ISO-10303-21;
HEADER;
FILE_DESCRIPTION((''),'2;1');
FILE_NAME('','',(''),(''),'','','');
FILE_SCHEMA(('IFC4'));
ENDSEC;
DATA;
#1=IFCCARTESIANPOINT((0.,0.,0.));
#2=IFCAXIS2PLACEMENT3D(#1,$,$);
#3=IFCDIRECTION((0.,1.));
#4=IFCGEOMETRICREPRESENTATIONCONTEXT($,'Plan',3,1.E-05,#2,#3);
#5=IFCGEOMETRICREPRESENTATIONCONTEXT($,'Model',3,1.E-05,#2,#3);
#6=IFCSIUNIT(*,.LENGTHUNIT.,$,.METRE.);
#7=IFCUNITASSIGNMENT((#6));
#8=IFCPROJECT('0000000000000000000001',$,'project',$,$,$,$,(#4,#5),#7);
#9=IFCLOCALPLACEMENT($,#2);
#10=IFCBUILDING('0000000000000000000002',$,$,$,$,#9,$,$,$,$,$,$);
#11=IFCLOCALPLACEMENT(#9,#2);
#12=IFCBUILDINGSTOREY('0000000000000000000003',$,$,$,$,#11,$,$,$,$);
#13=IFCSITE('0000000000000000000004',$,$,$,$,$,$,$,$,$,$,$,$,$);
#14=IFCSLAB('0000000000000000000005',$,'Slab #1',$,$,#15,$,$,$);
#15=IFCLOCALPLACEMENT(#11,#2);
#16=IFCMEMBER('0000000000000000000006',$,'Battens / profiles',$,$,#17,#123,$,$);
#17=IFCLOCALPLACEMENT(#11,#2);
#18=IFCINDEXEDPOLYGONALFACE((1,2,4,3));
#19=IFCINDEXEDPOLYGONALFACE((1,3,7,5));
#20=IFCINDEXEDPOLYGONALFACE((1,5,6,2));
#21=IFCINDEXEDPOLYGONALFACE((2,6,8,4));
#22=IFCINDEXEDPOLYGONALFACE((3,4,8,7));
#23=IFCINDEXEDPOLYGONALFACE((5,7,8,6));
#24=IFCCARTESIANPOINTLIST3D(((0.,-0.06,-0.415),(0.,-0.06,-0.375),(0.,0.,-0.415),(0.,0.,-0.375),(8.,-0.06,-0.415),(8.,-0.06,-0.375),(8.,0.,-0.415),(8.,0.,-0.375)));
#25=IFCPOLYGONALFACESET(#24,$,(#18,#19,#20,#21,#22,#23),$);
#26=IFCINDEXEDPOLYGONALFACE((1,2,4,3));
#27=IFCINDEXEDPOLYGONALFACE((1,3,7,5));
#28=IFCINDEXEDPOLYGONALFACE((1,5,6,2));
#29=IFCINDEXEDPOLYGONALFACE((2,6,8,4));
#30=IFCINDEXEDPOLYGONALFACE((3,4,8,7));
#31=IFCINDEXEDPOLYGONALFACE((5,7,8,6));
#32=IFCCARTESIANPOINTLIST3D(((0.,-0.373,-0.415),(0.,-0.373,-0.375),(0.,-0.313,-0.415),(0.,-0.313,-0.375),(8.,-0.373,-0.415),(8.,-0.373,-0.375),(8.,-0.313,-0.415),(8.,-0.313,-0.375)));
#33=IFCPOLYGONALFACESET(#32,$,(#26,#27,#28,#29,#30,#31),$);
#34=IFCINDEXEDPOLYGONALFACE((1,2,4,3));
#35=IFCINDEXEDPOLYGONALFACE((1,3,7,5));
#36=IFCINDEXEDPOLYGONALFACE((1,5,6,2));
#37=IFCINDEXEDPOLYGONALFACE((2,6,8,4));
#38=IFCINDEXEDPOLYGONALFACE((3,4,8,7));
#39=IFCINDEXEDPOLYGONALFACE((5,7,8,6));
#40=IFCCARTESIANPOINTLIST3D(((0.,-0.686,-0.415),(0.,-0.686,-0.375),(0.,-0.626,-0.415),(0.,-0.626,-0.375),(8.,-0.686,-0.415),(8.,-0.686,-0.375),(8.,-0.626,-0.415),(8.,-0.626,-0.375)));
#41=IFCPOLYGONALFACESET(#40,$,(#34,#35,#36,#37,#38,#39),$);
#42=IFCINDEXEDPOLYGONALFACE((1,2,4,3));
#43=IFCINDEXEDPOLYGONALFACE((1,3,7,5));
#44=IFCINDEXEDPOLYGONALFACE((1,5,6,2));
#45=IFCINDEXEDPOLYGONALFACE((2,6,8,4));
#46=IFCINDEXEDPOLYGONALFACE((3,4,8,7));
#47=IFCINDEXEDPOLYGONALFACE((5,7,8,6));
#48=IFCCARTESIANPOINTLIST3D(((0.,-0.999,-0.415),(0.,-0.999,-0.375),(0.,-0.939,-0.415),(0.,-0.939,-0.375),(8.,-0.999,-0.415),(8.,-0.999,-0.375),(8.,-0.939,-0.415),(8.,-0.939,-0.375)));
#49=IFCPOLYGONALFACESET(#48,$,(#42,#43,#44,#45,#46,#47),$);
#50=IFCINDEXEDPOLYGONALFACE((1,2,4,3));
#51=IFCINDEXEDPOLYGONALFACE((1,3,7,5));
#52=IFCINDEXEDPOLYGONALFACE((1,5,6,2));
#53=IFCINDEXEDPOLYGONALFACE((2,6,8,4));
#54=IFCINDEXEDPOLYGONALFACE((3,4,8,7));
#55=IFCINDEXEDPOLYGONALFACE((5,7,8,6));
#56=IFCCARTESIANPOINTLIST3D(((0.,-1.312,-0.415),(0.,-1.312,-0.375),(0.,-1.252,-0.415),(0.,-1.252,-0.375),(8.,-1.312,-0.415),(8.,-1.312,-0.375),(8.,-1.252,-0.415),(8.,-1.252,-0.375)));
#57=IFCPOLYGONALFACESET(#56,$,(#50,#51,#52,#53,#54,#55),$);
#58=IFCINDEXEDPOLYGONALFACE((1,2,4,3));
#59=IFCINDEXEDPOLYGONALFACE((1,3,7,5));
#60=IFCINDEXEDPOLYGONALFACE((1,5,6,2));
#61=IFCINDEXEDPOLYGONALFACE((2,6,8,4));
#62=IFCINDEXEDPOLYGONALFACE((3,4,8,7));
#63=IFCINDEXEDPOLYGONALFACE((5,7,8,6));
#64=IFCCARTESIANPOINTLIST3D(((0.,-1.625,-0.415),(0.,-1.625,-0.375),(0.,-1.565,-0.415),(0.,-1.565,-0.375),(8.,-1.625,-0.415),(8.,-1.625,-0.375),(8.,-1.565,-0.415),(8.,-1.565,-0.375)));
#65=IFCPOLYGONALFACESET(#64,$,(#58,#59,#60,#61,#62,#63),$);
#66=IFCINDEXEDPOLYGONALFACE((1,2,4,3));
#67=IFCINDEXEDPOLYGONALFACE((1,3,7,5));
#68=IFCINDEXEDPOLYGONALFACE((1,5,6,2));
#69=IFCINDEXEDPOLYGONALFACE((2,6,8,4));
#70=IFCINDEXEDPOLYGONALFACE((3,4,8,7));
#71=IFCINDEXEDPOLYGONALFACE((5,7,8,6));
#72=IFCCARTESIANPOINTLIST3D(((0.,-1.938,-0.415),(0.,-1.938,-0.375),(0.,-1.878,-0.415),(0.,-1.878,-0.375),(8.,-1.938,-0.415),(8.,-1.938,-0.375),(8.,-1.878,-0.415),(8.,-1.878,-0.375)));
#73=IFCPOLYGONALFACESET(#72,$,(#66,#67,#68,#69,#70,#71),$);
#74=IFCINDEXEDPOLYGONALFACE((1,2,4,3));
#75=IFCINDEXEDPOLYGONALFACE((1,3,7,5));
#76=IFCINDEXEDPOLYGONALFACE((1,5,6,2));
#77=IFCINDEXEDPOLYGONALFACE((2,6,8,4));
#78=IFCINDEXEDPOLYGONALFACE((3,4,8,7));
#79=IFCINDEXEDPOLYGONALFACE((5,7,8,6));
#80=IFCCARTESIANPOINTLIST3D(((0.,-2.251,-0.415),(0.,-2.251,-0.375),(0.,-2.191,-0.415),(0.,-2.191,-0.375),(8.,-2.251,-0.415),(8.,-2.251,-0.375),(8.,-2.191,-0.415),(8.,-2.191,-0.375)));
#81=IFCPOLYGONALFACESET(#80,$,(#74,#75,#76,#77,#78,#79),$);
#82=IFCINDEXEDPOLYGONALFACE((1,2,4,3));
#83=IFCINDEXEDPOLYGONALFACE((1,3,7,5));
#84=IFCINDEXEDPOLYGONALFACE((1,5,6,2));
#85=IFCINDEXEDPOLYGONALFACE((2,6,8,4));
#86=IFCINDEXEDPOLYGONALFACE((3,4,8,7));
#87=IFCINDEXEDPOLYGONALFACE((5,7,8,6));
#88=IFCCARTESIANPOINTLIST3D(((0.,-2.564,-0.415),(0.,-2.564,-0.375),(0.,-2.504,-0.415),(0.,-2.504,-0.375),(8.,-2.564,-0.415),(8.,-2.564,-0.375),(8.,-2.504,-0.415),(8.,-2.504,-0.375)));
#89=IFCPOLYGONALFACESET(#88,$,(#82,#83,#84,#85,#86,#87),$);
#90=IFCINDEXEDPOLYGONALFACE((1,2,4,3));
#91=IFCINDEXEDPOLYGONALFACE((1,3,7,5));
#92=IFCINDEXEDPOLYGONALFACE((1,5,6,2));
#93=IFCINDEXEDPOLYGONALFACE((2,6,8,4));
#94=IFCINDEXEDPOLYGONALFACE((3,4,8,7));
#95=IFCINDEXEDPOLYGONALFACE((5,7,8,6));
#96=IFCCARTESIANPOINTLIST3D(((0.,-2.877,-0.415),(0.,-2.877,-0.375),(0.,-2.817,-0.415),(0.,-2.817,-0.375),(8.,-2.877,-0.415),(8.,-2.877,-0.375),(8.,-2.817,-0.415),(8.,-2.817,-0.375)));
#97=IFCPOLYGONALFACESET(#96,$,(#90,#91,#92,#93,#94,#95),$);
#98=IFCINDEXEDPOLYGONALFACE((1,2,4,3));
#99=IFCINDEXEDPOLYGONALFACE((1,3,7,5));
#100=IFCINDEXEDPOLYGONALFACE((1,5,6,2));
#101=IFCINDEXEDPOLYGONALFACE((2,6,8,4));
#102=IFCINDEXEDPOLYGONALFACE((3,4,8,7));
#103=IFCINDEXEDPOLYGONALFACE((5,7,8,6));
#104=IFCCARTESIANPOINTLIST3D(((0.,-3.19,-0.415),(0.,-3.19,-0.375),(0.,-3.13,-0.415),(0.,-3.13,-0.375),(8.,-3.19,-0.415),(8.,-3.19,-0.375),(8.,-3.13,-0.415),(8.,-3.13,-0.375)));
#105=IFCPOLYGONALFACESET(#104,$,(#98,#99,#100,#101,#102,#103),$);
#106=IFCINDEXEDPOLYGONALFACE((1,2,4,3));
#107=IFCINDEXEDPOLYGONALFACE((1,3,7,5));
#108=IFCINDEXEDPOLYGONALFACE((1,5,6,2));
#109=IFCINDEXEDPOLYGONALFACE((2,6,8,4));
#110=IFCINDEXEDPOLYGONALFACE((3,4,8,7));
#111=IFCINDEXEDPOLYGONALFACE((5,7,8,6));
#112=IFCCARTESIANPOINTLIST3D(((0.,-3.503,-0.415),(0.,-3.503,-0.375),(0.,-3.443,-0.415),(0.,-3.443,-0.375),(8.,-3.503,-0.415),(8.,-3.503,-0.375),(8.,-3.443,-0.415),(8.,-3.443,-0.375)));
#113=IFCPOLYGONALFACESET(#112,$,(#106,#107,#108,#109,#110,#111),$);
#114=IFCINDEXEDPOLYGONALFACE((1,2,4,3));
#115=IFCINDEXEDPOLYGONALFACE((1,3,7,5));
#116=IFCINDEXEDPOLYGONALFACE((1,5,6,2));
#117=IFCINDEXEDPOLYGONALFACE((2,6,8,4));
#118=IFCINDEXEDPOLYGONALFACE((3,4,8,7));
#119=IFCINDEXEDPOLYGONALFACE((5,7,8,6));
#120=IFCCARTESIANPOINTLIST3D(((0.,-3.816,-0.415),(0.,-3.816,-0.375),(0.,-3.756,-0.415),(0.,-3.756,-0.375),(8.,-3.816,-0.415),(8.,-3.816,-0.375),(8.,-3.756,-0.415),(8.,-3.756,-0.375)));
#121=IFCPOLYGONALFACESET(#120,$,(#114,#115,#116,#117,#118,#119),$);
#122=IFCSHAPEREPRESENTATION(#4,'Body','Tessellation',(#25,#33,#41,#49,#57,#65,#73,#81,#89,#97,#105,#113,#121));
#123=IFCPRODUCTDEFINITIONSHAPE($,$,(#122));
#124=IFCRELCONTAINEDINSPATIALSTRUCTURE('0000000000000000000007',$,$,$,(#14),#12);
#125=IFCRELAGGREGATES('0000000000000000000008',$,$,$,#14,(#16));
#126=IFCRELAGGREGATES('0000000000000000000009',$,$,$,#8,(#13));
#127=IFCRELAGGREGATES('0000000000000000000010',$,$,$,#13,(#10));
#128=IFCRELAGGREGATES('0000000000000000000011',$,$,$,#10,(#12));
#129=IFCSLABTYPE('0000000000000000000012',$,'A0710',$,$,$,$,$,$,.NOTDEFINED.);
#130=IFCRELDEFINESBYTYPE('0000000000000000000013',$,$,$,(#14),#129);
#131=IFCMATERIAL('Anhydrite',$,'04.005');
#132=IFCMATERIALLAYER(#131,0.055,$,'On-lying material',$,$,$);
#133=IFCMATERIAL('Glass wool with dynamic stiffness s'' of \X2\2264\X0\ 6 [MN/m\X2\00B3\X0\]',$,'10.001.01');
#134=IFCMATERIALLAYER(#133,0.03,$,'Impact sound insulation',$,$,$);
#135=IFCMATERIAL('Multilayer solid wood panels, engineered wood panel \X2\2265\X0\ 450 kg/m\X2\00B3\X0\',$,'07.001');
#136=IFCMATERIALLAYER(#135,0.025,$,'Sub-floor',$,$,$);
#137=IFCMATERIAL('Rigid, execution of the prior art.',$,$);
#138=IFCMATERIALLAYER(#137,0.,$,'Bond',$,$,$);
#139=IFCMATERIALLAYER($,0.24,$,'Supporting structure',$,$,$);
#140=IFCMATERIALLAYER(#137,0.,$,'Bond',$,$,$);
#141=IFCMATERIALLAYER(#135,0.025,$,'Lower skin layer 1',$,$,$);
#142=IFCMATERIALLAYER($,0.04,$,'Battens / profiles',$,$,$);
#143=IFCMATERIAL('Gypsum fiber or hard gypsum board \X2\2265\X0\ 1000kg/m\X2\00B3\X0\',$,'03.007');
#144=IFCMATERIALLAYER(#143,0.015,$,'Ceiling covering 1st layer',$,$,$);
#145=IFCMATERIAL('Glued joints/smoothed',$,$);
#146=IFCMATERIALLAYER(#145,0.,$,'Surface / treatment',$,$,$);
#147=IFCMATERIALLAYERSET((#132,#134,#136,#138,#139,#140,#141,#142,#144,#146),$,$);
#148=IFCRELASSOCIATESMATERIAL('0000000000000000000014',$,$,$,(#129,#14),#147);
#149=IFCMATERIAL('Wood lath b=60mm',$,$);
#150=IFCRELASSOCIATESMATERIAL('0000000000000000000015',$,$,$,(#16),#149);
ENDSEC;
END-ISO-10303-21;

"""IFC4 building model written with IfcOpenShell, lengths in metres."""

from ifc_helpers import new_model, si_unit, direction, frame, frame_2d, origin, place, context, project, spatial, rectangle, extrude, material, layer, layer_set, type_object, element, aggregate, save


model = new_model("IFC4")

# Units and contexts
plan_context = context("Plan", 3, precision=1e-05, world=origin(), true_north=direction((0.0, 1.0)))
model_context = context("Model", 3, precision=1e-05, world=origin(), true_north=direction((0.0, 1.0)))
ifc_project = project(units=[si_unit("LENGTHUNIT", "METRE")], contexts=[plan_context, model_context])

# Site, building, storey
site = spatial("IfcSite", under=ifc_project)
building_placement = place(None, origin())
building = spatial("IfcBuilding", under=site, at=building_placement)
storey_placement = place(building_placement, origin())
storey = spatial("IfcBuildingStorey", under=building, at=storey_placement)

# Slab, member
ifc_material_1 = material(Name="Anhydrite", Category="04.005")
ifc_layer_1 = layer(ifc_material_1, 0.055, Name="On-lying material")
ifc_material_2 = material(Name="Glass wool with dynamic stiffness s' of ≤ 6 [MN/m³]", Category="10.001.01")
ifc_layer_2 = layer(ifc_material_2, 0.03, Name="Impact sound insulation")
ifc_material_3 = material(Name="Multilayer solid wood panels, engineered wood panel ≥ 450 kg/m³", Category="07.001")
ifc_layer_3 = layer(ifc_material_3, 0.025, Name="Sub-floor")
ifc_material_4 = material(Name="Rigid, execution of the prior art.")
ifc_layer_4 = layer(ifc_material_4, 0.0, Name="Bond")
ifc_layer_5 = layer(None, 0.24, Name="Supporting structure")
ifc_layer_6 = layer(ifc_material_4, 0.0, Name="Bond")
ifc_layer_7 = layer(ifc_material_3, 0.025, Name="Lower skin layer 1")
ifc_layer_8 = layer(None, 0.04, Name="Battens / profiles")
ifc_material_5 = material(Name="Gypsum fiber or hard gypsum board ≥ 1000kg/m³", Category="03.007")
ifc_layer_9 = layer(ifc_material_5, 0.015, Name="Ceiling covering 1st layer")
ifc_material_6 = material(Name="Glued joints/smoothed")
ifc_layer_10 = layer(ifc_material_6, 0.0, Name="Surface / treatment")
ifc_layer_set = layer_set([ifc_layer_1, ifc_layer_2, ifc_layer_3, ifc_layer_4, ifc_layer_5, ifc_layer_6, ifc_layer_7, ifc_layer_8, ifc_layer_9, ifc_layer_10])
slab_type = type_object("IfcSlabType", Name="A0710", PredefinedType="NOTDEFINED", material=ifc_layer_set)
slab_placement = place(None, frame((0.0, 0.0, 0.0), z_axis=(0.0, 0.0, -1.0), x_axis=(1.0, 0.0, 0.0)))
slab = element("IfcSlab", 1, at=slab_placement, inside=storey, type_object=slab_type, material=ifc_layer_set, Name="Slab #1")
ifc_material_7 = material(Name="Wood lath b=60mm")
member_1_placement = place(slab_placement, origin())
member_1 = element("IfcMember", 2, at=member_1_placement, material=ifc_material_7, Name="Battens / profiles", context=plan_context, shape_type="SweptSolid", body=[
    extrude(rectangle(XDim=0.06, YDim=0.04, at=frame_2d((0.03, 0.02), x_axis=(1.0, 0.0))), frame((0.0, 0.0, 0.375), z_axis=(1.0, 0.0, 0.0), x_axis=(0.0, 1.0, 0.0)), (0.0, 0.0, 1.0), 8.0),
    extrude(rectangle(XDim=0.06, YDim=0.04, at=frame_2d((0.03, 0.02), x_axis=(1.0, 0.0))), frame((0.0, 0.313, 0.375), z_axis=(1.0, 0.0, 0.0), x_axis=(0.0, 1.0, 0.0)), (0.0, 0.0, 1.0), 8.0),
    extrude(rectangle(XDim=0.06, YDim=0.04, at=frame_2d((0.03, 0.02), x_axis=(1.0, 0.0))), frame((0.0, 0.626, 0.375), z_axis=(1.0, 0.0, 0.0), x_axis=(0.0, 1.0, 0.0)), (0.0, 0.0, 1.0), 8.0),
    extrude(rectangle(XDim=0.06, YDim=0.04, at=frame_2d((0.03, 0.02), x_axis=(1.0, 0.0))), frame((0.0, 0.939, 0.375), z_axis=(1.0, 0.0, 0.0), x_axis=(0.0, 1.0, 0.0)), (0.0, 0.0, 1.0), 8.0),
    extrude(rectangle(XDim=0.06, YDim=0.04, at=frame_2d((0.03, 0.02), x_axis=(1.0, 0.0))), frame((0.0, 1.252, 0.375), z_axis=(1.0, 0.0, 0.0), x_axis=(0.0, 1.0, 0.0)), (0.0, 0.0, 1.0), 8.0),
    extrude(rectangle(XDim=0.06, YDim=0.04, at=frame_2d((0.03, 0.02), x_axis=(1.0, 0.0))), frame((0.0, 1.565, 0.375), z_axis=(1.0, 0.0, 0.0), x_axis=(0.0, 1.0, 0.0)), (0.0, 0.0, 1.0), 8.0),
    extrude(rectangle(XDim=0.06, YDim=0.04, at=frame_2d((0.03, 0.02), x_axis=(1.0, 0.0))), frame((0.0, 1.878, 0.375), z_axis=(1.0, 0.0, 0.0), x_axis=(0.0, 1.0, 0.0)), (0.0, 0.0, 1.0), 8.0),
    extrude(rectangle(XDim=0.06, YDim=0.04, at=frame_2d((0.03, 0.02), x_axis=(1.0, 0.0))), frame((0.0, 2.191, 0.375), z_axis=(1.0, 0.0, 0.0), x_axis=(0.0, 1.0, 0.0)), (0.0, 0.0, 1.0), 8.0),
    extrude(rectangle(XDim=0.06, YDim=0.04, at=frame_2d((0.03, 0.02), x_axis=(1.0, 0.0))), frame((0.0, 2.504, 0.375), z_axis=(1.0, 0.0, 0.0), x_axis=(0.0, 1.0, 0.0)), (0.0, 0.0, 1.0), 8.0),
    extrude(rectangle(XDim=0.06, YDim=0.04, at=frame_2d((0.03, 0.02), x_axis=(1.0, 0.0))), frame((0.0, 2.817, 0.375), z_axis=(1.0, 0.0, 0.0), x_axis=(0.0, 1.0, 0.0)), (0.0, 0.0, 1.0), 8.0),
    extrude(rectangle(XDim=0.06, YDim=0.04, at=frame_2d((0.03, 0.02), x_axis=(1.0, 0.0))), frame((0.0, 3.13, 0.375), z_axis=(1.0, 0.0, 0.0), x_axis=(0.0, 1.0, 0.0)), (0.0, 0.0, 1.0), 8.0),
    extrude(rectangle(XDim=0.06, YDim=0.04, at=frame_2d((0.03, 0.02), x_axis=(1.0, 0.0))), frame((0.0, 3.443, 0.375), z_axis=(1.0, 0.0, 0.0), x_axis=(0.0, 1.0, 0.0)), (0.0, 0.0, 1.0), 8.0),
    extrude(rectangle(XDim=0.06, YDim=0.04, at=frame_2d((0.03, 0.02), x_axis=(1.0, 0.0))), frame((0.0, 3.756, 0.375), z_axis=(1.0, 0.0, 0.0), x_axis=(0.0, 1.0, 0.0)), (0.0, 0.0, 1.0), 8.0),
])
aggregate(slab, [member_1])

save(model, "model.ifc")
